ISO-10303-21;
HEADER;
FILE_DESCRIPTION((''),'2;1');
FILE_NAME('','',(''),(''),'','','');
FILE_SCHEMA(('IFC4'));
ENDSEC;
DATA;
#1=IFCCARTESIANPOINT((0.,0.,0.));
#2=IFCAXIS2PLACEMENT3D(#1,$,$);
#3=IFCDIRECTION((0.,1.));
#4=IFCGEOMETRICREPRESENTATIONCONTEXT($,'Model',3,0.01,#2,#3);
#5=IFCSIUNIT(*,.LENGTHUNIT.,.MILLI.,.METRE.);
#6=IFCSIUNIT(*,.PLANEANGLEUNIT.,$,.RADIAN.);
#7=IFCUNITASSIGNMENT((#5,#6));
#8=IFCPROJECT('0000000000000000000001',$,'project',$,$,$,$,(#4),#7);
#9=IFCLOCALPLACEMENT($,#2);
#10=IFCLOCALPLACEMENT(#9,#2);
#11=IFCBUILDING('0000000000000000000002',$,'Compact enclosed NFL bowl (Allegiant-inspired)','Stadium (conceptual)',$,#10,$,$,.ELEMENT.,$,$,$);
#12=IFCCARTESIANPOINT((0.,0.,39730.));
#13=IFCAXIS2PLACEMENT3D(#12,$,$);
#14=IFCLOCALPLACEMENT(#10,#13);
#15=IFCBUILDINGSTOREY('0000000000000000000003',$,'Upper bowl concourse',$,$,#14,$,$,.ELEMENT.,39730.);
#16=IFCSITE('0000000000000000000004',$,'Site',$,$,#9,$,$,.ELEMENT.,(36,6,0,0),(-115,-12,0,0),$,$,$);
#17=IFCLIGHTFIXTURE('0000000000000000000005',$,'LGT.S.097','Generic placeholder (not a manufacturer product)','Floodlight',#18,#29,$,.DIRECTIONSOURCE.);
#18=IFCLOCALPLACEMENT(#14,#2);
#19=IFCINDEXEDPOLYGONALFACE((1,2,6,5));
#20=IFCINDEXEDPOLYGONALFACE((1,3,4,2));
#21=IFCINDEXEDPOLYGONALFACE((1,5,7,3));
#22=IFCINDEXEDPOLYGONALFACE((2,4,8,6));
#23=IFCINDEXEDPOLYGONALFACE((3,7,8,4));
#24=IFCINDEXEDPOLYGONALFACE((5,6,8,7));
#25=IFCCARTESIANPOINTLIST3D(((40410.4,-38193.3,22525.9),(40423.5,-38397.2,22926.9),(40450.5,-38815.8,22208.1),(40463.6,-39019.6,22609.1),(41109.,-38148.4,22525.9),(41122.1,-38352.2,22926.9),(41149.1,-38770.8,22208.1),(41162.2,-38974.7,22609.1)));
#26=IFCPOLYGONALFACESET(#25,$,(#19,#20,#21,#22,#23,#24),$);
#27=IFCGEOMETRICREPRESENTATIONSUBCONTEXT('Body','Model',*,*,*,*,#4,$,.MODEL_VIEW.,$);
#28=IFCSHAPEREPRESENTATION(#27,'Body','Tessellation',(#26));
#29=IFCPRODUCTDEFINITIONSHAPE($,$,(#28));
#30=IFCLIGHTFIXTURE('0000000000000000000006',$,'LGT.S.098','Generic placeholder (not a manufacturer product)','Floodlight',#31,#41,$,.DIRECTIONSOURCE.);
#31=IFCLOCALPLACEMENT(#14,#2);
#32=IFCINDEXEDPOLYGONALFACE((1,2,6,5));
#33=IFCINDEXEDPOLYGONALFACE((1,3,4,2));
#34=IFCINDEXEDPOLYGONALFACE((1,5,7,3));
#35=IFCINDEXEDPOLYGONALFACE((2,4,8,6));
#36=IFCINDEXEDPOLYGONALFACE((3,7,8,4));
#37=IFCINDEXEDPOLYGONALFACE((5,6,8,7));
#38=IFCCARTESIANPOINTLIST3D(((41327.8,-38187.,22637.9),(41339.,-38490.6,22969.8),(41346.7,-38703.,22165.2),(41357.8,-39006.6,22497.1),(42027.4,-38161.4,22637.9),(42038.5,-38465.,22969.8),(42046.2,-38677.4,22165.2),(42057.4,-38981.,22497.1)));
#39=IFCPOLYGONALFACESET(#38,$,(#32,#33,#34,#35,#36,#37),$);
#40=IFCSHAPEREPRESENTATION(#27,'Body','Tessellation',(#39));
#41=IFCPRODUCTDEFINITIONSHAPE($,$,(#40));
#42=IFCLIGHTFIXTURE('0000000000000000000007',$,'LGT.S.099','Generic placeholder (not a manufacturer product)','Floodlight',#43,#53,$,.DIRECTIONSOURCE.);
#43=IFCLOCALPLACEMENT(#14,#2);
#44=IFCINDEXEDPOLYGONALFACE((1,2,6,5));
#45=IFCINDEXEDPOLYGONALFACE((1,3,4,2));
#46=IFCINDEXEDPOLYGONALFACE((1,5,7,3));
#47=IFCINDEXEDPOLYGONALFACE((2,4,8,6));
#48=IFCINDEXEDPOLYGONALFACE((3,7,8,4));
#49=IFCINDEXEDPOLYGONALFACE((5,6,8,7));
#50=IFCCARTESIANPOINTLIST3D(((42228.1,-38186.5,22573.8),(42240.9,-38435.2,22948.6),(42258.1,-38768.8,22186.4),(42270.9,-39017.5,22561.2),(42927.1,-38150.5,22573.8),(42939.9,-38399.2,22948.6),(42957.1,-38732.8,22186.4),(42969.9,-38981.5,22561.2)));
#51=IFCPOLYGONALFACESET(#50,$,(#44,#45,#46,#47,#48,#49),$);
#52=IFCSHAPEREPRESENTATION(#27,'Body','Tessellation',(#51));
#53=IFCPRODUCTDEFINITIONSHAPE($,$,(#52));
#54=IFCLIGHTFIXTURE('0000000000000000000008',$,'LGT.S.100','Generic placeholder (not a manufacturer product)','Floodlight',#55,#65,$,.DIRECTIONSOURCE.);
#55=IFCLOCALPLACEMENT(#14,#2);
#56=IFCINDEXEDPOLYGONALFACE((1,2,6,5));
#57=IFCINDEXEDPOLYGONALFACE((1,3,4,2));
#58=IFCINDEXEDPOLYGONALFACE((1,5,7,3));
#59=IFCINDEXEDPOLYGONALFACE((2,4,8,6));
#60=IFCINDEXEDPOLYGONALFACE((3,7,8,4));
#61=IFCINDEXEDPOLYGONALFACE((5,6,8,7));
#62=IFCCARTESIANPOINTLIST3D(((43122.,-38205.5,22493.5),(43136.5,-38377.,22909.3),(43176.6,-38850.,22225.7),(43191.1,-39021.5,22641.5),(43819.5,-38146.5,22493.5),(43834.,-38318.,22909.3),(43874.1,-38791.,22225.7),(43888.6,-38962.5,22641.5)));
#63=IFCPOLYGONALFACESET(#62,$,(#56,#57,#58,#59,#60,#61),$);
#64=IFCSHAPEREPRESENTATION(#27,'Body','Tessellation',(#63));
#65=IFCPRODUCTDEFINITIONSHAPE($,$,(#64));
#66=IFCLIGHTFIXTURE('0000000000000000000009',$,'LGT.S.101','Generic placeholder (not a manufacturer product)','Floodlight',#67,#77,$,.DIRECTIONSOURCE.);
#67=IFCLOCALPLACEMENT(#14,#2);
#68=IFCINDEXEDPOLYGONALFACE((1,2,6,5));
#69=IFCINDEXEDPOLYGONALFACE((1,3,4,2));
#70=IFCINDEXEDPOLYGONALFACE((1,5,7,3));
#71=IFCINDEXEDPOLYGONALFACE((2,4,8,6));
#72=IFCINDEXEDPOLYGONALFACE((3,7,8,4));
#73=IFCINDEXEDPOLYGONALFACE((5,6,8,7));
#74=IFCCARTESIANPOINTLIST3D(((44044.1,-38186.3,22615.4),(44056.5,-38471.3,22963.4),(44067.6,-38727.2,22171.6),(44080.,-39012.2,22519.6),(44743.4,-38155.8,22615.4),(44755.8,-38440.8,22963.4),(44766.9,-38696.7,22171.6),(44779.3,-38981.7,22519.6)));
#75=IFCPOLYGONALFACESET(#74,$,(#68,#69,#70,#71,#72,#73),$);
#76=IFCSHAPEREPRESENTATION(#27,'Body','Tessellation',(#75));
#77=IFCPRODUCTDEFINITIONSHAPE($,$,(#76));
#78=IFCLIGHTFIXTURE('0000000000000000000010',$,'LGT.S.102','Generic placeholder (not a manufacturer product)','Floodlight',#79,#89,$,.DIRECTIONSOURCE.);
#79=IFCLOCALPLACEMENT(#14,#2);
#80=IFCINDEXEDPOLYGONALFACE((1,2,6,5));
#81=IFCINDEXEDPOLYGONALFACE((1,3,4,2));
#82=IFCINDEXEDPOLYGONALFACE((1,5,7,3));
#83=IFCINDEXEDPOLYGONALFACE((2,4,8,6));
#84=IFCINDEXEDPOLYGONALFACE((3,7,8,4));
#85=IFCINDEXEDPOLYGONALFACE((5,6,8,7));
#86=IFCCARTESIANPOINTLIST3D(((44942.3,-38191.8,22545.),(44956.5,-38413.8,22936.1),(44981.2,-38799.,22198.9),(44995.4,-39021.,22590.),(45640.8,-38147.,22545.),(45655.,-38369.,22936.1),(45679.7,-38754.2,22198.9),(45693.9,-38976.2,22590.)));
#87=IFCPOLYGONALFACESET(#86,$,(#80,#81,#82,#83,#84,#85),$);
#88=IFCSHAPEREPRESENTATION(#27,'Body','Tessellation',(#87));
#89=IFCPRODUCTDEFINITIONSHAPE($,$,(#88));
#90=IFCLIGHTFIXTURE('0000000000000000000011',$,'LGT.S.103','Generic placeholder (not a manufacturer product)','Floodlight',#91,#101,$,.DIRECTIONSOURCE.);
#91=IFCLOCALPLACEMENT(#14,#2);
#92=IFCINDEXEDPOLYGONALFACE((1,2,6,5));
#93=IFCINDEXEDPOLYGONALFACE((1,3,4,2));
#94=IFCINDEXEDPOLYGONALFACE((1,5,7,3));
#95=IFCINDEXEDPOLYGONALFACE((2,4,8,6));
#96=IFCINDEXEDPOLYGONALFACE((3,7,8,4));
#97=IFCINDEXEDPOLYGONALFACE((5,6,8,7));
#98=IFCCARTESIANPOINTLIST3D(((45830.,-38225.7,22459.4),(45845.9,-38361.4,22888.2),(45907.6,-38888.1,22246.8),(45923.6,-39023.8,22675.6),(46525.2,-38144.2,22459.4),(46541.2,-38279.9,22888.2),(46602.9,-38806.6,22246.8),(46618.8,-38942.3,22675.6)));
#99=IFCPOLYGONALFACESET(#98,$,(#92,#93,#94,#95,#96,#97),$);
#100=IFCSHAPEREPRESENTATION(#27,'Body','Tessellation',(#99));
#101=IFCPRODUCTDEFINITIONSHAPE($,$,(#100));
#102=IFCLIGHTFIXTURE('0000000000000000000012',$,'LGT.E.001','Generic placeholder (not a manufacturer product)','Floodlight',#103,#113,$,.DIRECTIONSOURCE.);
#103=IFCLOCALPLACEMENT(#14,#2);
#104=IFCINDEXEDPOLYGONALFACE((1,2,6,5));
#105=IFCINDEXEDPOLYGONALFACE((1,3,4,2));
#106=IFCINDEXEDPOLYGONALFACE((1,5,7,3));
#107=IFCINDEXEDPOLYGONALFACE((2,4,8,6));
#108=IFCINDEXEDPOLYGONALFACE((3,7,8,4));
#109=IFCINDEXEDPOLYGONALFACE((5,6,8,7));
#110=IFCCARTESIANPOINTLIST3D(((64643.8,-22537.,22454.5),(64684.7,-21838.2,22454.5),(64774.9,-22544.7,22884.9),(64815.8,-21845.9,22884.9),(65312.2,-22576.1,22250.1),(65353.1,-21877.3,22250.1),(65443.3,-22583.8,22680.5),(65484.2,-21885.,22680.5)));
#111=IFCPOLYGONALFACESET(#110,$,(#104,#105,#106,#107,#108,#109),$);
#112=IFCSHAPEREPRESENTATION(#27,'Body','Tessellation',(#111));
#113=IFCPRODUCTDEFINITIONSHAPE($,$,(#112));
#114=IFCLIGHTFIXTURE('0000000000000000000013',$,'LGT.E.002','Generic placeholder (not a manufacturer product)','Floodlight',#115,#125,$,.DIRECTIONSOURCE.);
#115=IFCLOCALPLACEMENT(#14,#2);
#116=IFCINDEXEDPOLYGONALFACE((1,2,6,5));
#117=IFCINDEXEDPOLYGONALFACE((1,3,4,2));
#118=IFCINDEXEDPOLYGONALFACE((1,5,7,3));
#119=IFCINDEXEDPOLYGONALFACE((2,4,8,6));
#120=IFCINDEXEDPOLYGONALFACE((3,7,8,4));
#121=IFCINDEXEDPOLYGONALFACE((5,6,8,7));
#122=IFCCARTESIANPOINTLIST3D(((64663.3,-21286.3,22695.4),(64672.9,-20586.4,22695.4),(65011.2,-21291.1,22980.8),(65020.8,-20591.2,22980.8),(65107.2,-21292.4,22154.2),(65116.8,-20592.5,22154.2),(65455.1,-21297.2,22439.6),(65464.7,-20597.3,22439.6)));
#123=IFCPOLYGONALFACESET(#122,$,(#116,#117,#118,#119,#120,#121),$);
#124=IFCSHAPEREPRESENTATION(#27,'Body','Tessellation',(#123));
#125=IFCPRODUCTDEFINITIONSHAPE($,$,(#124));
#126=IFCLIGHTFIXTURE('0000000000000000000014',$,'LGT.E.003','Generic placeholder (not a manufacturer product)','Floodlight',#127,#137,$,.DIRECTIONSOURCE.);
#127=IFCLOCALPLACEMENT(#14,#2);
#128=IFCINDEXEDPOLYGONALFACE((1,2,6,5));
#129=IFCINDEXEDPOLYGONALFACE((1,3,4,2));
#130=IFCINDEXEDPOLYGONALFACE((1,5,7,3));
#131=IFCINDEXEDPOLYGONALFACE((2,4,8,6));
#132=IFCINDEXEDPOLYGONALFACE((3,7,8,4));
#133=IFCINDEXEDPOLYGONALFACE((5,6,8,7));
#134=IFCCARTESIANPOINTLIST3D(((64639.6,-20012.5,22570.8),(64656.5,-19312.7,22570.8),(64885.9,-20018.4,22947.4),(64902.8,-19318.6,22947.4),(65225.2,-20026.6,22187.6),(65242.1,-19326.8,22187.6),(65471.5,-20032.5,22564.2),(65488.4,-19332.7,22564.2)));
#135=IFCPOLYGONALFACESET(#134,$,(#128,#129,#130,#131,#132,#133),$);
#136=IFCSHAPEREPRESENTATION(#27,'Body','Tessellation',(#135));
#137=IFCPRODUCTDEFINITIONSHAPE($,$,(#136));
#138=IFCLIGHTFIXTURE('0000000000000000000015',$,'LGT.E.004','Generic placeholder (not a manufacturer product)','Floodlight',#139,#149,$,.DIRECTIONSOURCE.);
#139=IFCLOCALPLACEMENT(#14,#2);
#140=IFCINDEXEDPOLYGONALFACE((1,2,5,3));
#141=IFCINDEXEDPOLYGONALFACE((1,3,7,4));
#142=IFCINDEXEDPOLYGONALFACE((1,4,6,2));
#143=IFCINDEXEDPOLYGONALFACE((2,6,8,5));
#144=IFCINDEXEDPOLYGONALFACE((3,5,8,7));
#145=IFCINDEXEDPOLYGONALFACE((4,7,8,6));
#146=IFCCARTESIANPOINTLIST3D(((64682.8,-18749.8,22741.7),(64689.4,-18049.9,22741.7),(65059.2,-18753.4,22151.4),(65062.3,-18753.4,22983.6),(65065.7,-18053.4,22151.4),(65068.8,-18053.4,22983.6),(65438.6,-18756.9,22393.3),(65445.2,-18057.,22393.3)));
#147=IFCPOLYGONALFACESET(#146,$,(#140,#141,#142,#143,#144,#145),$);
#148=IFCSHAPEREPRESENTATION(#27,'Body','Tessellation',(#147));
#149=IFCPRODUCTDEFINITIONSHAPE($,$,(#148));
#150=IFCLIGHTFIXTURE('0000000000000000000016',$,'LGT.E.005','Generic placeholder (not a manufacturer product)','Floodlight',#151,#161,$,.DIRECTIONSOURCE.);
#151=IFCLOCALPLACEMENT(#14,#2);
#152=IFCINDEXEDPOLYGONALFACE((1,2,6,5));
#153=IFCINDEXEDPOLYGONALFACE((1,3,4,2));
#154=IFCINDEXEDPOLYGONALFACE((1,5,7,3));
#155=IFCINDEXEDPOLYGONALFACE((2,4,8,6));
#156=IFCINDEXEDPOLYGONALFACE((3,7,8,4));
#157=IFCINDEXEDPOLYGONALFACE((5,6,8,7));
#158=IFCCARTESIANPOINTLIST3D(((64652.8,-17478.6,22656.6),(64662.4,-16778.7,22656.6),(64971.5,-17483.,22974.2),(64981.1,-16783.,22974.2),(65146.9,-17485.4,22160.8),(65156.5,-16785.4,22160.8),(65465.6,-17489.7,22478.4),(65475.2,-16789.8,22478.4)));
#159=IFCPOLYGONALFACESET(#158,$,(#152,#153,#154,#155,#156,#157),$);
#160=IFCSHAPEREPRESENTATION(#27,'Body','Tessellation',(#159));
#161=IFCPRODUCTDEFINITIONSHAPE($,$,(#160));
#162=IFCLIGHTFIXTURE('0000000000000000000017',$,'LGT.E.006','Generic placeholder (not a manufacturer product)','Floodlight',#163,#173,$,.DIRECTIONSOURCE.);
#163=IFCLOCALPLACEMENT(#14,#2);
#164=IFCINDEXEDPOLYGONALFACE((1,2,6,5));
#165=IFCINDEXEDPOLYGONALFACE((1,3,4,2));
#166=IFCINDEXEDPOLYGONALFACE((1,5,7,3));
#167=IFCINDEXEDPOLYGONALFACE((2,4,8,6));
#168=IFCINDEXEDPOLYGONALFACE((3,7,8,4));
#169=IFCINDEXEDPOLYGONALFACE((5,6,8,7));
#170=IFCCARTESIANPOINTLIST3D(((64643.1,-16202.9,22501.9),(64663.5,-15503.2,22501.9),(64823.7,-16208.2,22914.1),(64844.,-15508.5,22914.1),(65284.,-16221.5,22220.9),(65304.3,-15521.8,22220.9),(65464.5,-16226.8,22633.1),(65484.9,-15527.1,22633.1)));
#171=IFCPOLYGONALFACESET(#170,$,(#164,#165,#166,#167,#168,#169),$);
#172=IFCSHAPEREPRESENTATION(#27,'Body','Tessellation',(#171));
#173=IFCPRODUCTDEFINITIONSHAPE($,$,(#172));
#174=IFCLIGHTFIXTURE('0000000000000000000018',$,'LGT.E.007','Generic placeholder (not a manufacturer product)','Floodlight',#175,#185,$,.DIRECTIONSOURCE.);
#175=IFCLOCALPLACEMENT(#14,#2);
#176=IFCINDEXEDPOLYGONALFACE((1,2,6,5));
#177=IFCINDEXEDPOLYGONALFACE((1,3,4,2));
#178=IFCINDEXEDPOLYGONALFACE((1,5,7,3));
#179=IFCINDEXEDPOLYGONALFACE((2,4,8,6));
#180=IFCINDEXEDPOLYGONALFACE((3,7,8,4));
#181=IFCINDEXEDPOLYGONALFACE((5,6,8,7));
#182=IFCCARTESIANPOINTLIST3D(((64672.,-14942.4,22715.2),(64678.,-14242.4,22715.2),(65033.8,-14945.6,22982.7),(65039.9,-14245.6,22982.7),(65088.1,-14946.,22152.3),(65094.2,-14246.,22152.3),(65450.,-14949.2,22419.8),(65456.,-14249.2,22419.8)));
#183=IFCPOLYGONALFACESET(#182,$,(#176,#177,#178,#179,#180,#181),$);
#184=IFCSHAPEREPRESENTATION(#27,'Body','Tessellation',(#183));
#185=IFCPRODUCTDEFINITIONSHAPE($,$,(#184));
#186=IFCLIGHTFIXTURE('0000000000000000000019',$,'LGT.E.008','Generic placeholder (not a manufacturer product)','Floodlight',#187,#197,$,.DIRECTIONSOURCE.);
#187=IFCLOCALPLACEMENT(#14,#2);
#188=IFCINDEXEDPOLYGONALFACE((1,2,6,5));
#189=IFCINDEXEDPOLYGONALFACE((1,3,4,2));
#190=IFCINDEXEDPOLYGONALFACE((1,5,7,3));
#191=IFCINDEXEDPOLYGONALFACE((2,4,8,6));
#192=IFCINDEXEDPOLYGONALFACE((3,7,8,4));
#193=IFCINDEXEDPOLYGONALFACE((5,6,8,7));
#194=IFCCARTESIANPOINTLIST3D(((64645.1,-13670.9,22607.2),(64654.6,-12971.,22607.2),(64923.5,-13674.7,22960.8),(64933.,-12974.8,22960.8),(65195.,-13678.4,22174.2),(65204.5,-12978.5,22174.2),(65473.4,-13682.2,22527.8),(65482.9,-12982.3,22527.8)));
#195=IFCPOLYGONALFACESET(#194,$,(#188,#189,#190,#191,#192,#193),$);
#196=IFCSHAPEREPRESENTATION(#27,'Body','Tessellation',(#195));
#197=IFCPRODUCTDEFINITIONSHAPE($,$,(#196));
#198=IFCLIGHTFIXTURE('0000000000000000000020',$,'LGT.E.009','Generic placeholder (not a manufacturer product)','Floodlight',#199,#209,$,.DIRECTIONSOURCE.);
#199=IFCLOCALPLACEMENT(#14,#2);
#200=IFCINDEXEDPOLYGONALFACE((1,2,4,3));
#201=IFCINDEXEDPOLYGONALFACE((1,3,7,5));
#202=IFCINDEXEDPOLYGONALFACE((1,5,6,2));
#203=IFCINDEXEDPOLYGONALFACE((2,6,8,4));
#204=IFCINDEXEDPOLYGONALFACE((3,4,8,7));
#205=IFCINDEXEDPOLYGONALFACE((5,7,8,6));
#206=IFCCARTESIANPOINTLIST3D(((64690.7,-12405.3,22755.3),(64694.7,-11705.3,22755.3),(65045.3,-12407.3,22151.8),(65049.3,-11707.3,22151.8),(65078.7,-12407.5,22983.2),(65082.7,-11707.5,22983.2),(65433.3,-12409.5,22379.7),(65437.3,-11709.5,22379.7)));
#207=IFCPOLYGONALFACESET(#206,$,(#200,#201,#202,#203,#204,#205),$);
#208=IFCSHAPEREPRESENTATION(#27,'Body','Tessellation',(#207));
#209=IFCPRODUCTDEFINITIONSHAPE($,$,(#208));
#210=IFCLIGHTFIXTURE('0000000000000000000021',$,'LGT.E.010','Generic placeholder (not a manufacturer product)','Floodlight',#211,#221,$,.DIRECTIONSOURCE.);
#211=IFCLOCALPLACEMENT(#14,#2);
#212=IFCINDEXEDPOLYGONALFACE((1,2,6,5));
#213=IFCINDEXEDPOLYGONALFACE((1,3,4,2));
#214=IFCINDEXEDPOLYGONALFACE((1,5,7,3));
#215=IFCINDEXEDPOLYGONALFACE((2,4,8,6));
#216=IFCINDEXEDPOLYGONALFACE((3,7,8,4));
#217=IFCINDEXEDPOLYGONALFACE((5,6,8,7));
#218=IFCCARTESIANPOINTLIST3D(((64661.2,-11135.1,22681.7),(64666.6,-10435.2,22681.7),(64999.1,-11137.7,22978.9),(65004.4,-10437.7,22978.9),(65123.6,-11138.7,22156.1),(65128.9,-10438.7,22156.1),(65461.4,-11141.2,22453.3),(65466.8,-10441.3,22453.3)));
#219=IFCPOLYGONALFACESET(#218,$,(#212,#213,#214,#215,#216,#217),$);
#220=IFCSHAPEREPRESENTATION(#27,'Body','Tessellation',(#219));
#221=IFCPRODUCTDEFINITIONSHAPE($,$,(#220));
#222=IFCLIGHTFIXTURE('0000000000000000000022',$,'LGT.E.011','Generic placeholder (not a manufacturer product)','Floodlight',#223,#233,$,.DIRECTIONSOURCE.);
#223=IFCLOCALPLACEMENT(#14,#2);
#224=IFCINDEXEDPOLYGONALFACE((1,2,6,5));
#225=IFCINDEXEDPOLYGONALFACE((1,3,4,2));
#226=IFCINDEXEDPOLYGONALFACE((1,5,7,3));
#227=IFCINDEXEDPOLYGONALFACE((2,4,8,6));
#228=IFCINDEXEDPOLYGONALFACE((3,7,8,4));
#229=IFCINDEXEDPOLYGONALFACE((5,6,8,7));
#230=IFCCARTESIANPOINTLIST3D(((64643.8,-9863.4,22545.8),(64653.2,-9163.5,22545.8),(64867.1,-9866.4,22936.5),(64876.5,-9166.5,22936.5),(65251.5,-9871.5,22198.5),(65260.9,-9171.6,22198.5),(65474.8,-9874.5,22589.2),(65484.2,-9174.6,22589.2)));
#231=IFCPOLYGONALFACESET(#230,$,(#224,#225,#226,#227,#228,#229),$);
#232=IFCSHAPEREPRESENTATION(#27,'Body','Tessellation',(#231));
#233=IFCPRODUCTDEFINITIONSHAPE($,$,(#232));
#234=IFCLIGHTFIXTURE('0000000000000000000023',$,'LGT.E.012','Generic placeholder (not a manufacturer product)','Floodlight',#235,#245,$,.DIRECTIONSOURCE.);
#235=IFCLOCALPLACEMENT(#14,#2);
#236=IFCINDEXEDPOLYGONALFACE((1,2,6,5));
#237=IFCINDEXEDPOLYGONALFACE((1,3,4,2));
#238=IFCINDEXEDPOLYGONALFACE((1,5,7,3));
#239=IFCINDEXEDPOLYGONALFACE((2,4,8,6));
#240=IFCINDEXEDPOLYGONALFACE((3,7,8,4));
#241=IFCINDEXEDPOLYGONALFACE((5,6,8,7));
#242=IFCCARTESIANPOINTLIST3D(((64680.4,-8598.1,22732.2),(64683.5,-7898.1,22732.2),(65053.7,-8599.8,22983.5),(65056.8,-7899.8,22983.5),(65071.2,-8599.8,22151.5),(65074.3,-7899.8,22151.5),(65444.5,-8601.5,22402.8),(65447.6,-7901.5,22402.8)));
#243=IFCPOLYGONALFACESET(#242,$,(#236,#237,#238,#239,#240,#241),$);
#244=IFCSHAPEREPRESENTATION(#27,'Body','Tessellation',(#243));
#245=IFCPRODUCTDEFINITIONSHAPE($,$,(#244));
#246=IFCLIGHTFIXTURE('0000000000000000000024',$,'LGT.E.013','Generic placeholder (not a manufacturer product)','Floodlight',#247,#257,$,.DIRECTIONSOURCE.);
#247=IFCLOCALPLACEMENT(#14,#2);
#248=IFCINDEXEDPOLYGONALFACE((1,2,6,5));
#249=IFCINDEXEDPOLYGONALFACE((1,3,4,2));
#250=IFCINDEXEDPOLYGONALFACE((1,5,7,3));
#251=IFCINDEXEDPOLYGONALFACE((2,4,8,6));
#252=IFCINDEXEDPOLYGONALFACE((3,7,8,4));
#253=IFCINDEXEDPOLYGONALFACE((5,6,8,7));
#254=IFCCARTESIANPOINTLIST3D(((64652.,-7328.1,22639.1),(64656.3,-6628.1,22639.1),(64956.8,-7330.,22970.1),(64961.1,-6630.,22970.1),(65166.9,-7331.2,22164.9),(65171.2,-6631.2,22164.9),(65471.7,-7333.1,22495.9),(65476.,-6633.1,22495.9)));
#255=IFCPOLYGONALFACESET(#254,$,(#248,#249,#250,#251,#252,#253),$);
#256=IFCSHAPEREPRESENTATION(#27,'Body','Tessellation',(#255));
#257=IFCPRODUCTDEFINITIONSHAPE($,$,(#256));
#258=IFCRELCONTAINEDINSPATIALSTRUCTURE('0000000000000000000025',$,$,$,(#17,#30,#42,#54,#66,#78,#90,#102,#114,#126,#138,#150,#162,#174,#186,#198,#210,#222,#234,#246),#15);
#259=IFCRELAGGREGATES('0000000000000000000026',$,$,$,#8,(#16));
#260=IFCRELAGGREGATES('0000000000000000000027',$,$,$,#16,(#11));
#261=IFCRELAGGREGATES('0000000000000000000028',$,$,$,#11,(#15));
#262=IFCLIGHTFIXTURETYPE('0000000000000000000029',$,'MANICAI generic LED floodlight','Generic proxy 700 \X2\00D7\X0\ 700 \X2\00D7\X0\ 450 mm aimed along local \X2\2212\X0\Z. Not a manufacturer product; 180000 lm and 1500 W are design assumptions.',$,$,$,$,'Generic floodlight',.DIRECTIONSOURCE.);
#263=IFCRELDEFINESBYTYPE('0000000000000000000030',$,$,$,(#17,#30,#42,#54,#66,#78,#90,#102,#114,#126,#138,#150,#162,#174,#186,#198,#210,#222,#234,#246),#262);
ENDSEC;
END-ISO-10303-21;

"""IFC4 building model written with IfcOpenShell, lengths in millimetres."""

from ifc_helpers import new_model, si_unit, direction, frame, origin, place, context, subcontext, project, spatial, rectangle, extrude, source, transform, mapped, type_object, type_shapes, element, save


model = new_model("IFC4")

# Units and contexts
model_context = context("Model", 3, precision=0.01, world=origin(), true_north=direction((0.0, 1.0)))
body_context = subcontext(model_context, "Body", "Model", "MODEL_VIEW")
ifc_project = project(units=[si_unit("LENGTHUNIT", "METRE", prefix="MILLI"), si_unit("PLANEANGLEUNIT", "RADIAN")], contexts=[model_context])

# Site, building, storey
site_placement = place(None, origin())
site = spatial("IfcSite", under=ifc_project, at=site_placement, Name="Site", CompositionType="ELEMENT", RefLatitude=(36, 6, 0, 0), RefLongitude=(-115, -12, 0, 0))
building_placement = place(site_placement, origin())
building = spatial("IfcBuilding", under=site, at=building_placement, Name="Compact enclosed NFL bowl (Allegiant-inspired)", Description="Stadium (conceptual)", CompositionType="ELEMENT")
storey_placement = place(building_placement, frame((0.0, 0.0, 39730.0)))
storey = spatial("IfcBuildingStorey", under=building, at=storey_placement, Name="Upper bowl concourse", CompositionType="ELEMENT", Elevation=39730.0)

# Light fixtures
light_fixture_type = type_object("IfcLightFixtureType", Name="MANICAI generic LED floodlight", Description="Generic proxy 700 × 700 × 450 mm aimed along local −Z. Not a manufacturer product; 180000 lm and 1500 W are design assumptions.", ElementType="Generic floodlight", PredefinedType="DIRECTIONSOURCE")
shared_shape = source(origin(), body_context, "Body", "SweptSolid", [
    extrude(rectangle(XDim=700.0, YDim=700.0), frame((0.0, 0.0, -225.0)), (0.0, 0.0, 1.0), 450.0),
])
type_shapes(light_fixture_type, [shared_shape])
for number, where, z_axis, x_axis, name in (
    (1, (40786.3, -38584.0, 22567.5), (0.029168, -0.452997, 0.891035), (0.997933, 0.064256, 0.0), "LGT.S.097"),
    (2, (41692.6, -38584.0, 22567.5), (0.024683, -0.674769, 0.737616), (0.999332, 0.036555, 0.0), "LGT.S.098"),
    (3, (42599.0, -38584.0, 22567.5), (0.028476, -0.552721, 0.83288), (0.998675, 0.051452, 0.0), "LGT.S.099"),
    (4, (43505.3, -38584.0, 22567.5), (0.032263, -0.381097, 0.923972), (0.996436, 0.084356, 0.0), "LGT.S.100"),
    (5, (44411.7, -38584.0, 22567.5), (0.027568, -0.63331, 0.773407), (0.999054, 0.043489, 0.0), "LGT.S.101"),
    (6, (45318.1, -38584.0, 22567.5), (0.031615, -0.493437, 0.869206), (0.997954, 0.06394, 0.0), "LGT.S.102"),
    (7, (46224.4, -38584.0, 22567.5), (0.035348, -0.301573, 0.952788), (0.993201, 0.116416, 0.0), "LGT.S.103"),
    (8, (65064.0, -22211.0, 22567.5), (0.291374, -0.01705, 0.956457), (0.058417, 0.998292, 0.0), "LGT.E.001"),
    (9, (65064.0, -20941.8, 22567.5), (0.773104, -0.010659, 0.634189), (0.013786, 0.999905, 0.0), "LGT.E.002"),
    (10, (65064.0, -19672.6, 22567.5), (0.547239, -0.013214, 0.836872), (0.024139, 0.999709, 0.0), "LGT.E.003"),
    (11, (65064.0, -18403.4, 22567.5), (0.843152, -0.007941, 0.537616), (0.009418, 0.999956, 0.0), "LGT.E.004"),
    (12, (65064.0, -17134.2, 22567.5), (0.708196, -0.009708, 0.705949), (0.013707, 0.999906, 0.0), "LGT.E.005"),
    (13, (65064.0, -15865.0, 22567.5), (0.401213, -0.011663, 0.91591), (0.029056, 0.999578, 0.0), "LGT.E.006"),
    (14, (65064.0, -14595.8, 22567.5), (0.804054, -0.006965, 0.594515), (0.008661, 0.999962, 0.0), "LGT.E.007"),
    (15, (65064.0, -13326.6, 22567.5), (0.61858, -0.008404, 0.785677), (0.013584, 0.999908, 0.0), "LGT.E.008"),
    (16, (65064.0, -12057.4, 22567.5), (0.862149, -0.004903, 0.506632), (0.005687, 0.999984, 0.0), "LGT.E.009"),
    (17, (65064.0, -10788.2, 22567.5), (0.750767, -0.005719, 0.660542), (0.007618, 0.999971, 0.0), "LGT.E.010"),
    (18, (65064.0, -9519.0, 22567.5), (0.496148, -0.006633, 0.868213), (0.013368, 0.999911, 0.0), "LGT.E.011"),
    (19, (65064.0, -8249.8, 22567.5), (0.829608, -0.003697, 0.558334), (0.004456, 0.99999, 0.0), "LGT.E.012"),
    (20, (65064.0, -6980.6, 22567.5), (0.677342, -0.004122, 0.735657), (0.006085, 0.999981, 0.0), "LGT.E.013"),
):
    element("IfcLightFixture", number, at=place(storey_placement, frame(where, z_axis=z_axis, x_axis=x_axis)), inside=storey, type_object=light_fixture_type, Name=name, Description="Generic placeholder (not a manufacturer product)", ObjectType="Floodlight", PredefinedType="DIRECTIONSOURCE", context=body_context, shape_type="MappedRepresentation", body=[
        mapped(shared_shape, transform((0.0, 0.0, 0.0))),
    ])

save(model, "model.ifc")
